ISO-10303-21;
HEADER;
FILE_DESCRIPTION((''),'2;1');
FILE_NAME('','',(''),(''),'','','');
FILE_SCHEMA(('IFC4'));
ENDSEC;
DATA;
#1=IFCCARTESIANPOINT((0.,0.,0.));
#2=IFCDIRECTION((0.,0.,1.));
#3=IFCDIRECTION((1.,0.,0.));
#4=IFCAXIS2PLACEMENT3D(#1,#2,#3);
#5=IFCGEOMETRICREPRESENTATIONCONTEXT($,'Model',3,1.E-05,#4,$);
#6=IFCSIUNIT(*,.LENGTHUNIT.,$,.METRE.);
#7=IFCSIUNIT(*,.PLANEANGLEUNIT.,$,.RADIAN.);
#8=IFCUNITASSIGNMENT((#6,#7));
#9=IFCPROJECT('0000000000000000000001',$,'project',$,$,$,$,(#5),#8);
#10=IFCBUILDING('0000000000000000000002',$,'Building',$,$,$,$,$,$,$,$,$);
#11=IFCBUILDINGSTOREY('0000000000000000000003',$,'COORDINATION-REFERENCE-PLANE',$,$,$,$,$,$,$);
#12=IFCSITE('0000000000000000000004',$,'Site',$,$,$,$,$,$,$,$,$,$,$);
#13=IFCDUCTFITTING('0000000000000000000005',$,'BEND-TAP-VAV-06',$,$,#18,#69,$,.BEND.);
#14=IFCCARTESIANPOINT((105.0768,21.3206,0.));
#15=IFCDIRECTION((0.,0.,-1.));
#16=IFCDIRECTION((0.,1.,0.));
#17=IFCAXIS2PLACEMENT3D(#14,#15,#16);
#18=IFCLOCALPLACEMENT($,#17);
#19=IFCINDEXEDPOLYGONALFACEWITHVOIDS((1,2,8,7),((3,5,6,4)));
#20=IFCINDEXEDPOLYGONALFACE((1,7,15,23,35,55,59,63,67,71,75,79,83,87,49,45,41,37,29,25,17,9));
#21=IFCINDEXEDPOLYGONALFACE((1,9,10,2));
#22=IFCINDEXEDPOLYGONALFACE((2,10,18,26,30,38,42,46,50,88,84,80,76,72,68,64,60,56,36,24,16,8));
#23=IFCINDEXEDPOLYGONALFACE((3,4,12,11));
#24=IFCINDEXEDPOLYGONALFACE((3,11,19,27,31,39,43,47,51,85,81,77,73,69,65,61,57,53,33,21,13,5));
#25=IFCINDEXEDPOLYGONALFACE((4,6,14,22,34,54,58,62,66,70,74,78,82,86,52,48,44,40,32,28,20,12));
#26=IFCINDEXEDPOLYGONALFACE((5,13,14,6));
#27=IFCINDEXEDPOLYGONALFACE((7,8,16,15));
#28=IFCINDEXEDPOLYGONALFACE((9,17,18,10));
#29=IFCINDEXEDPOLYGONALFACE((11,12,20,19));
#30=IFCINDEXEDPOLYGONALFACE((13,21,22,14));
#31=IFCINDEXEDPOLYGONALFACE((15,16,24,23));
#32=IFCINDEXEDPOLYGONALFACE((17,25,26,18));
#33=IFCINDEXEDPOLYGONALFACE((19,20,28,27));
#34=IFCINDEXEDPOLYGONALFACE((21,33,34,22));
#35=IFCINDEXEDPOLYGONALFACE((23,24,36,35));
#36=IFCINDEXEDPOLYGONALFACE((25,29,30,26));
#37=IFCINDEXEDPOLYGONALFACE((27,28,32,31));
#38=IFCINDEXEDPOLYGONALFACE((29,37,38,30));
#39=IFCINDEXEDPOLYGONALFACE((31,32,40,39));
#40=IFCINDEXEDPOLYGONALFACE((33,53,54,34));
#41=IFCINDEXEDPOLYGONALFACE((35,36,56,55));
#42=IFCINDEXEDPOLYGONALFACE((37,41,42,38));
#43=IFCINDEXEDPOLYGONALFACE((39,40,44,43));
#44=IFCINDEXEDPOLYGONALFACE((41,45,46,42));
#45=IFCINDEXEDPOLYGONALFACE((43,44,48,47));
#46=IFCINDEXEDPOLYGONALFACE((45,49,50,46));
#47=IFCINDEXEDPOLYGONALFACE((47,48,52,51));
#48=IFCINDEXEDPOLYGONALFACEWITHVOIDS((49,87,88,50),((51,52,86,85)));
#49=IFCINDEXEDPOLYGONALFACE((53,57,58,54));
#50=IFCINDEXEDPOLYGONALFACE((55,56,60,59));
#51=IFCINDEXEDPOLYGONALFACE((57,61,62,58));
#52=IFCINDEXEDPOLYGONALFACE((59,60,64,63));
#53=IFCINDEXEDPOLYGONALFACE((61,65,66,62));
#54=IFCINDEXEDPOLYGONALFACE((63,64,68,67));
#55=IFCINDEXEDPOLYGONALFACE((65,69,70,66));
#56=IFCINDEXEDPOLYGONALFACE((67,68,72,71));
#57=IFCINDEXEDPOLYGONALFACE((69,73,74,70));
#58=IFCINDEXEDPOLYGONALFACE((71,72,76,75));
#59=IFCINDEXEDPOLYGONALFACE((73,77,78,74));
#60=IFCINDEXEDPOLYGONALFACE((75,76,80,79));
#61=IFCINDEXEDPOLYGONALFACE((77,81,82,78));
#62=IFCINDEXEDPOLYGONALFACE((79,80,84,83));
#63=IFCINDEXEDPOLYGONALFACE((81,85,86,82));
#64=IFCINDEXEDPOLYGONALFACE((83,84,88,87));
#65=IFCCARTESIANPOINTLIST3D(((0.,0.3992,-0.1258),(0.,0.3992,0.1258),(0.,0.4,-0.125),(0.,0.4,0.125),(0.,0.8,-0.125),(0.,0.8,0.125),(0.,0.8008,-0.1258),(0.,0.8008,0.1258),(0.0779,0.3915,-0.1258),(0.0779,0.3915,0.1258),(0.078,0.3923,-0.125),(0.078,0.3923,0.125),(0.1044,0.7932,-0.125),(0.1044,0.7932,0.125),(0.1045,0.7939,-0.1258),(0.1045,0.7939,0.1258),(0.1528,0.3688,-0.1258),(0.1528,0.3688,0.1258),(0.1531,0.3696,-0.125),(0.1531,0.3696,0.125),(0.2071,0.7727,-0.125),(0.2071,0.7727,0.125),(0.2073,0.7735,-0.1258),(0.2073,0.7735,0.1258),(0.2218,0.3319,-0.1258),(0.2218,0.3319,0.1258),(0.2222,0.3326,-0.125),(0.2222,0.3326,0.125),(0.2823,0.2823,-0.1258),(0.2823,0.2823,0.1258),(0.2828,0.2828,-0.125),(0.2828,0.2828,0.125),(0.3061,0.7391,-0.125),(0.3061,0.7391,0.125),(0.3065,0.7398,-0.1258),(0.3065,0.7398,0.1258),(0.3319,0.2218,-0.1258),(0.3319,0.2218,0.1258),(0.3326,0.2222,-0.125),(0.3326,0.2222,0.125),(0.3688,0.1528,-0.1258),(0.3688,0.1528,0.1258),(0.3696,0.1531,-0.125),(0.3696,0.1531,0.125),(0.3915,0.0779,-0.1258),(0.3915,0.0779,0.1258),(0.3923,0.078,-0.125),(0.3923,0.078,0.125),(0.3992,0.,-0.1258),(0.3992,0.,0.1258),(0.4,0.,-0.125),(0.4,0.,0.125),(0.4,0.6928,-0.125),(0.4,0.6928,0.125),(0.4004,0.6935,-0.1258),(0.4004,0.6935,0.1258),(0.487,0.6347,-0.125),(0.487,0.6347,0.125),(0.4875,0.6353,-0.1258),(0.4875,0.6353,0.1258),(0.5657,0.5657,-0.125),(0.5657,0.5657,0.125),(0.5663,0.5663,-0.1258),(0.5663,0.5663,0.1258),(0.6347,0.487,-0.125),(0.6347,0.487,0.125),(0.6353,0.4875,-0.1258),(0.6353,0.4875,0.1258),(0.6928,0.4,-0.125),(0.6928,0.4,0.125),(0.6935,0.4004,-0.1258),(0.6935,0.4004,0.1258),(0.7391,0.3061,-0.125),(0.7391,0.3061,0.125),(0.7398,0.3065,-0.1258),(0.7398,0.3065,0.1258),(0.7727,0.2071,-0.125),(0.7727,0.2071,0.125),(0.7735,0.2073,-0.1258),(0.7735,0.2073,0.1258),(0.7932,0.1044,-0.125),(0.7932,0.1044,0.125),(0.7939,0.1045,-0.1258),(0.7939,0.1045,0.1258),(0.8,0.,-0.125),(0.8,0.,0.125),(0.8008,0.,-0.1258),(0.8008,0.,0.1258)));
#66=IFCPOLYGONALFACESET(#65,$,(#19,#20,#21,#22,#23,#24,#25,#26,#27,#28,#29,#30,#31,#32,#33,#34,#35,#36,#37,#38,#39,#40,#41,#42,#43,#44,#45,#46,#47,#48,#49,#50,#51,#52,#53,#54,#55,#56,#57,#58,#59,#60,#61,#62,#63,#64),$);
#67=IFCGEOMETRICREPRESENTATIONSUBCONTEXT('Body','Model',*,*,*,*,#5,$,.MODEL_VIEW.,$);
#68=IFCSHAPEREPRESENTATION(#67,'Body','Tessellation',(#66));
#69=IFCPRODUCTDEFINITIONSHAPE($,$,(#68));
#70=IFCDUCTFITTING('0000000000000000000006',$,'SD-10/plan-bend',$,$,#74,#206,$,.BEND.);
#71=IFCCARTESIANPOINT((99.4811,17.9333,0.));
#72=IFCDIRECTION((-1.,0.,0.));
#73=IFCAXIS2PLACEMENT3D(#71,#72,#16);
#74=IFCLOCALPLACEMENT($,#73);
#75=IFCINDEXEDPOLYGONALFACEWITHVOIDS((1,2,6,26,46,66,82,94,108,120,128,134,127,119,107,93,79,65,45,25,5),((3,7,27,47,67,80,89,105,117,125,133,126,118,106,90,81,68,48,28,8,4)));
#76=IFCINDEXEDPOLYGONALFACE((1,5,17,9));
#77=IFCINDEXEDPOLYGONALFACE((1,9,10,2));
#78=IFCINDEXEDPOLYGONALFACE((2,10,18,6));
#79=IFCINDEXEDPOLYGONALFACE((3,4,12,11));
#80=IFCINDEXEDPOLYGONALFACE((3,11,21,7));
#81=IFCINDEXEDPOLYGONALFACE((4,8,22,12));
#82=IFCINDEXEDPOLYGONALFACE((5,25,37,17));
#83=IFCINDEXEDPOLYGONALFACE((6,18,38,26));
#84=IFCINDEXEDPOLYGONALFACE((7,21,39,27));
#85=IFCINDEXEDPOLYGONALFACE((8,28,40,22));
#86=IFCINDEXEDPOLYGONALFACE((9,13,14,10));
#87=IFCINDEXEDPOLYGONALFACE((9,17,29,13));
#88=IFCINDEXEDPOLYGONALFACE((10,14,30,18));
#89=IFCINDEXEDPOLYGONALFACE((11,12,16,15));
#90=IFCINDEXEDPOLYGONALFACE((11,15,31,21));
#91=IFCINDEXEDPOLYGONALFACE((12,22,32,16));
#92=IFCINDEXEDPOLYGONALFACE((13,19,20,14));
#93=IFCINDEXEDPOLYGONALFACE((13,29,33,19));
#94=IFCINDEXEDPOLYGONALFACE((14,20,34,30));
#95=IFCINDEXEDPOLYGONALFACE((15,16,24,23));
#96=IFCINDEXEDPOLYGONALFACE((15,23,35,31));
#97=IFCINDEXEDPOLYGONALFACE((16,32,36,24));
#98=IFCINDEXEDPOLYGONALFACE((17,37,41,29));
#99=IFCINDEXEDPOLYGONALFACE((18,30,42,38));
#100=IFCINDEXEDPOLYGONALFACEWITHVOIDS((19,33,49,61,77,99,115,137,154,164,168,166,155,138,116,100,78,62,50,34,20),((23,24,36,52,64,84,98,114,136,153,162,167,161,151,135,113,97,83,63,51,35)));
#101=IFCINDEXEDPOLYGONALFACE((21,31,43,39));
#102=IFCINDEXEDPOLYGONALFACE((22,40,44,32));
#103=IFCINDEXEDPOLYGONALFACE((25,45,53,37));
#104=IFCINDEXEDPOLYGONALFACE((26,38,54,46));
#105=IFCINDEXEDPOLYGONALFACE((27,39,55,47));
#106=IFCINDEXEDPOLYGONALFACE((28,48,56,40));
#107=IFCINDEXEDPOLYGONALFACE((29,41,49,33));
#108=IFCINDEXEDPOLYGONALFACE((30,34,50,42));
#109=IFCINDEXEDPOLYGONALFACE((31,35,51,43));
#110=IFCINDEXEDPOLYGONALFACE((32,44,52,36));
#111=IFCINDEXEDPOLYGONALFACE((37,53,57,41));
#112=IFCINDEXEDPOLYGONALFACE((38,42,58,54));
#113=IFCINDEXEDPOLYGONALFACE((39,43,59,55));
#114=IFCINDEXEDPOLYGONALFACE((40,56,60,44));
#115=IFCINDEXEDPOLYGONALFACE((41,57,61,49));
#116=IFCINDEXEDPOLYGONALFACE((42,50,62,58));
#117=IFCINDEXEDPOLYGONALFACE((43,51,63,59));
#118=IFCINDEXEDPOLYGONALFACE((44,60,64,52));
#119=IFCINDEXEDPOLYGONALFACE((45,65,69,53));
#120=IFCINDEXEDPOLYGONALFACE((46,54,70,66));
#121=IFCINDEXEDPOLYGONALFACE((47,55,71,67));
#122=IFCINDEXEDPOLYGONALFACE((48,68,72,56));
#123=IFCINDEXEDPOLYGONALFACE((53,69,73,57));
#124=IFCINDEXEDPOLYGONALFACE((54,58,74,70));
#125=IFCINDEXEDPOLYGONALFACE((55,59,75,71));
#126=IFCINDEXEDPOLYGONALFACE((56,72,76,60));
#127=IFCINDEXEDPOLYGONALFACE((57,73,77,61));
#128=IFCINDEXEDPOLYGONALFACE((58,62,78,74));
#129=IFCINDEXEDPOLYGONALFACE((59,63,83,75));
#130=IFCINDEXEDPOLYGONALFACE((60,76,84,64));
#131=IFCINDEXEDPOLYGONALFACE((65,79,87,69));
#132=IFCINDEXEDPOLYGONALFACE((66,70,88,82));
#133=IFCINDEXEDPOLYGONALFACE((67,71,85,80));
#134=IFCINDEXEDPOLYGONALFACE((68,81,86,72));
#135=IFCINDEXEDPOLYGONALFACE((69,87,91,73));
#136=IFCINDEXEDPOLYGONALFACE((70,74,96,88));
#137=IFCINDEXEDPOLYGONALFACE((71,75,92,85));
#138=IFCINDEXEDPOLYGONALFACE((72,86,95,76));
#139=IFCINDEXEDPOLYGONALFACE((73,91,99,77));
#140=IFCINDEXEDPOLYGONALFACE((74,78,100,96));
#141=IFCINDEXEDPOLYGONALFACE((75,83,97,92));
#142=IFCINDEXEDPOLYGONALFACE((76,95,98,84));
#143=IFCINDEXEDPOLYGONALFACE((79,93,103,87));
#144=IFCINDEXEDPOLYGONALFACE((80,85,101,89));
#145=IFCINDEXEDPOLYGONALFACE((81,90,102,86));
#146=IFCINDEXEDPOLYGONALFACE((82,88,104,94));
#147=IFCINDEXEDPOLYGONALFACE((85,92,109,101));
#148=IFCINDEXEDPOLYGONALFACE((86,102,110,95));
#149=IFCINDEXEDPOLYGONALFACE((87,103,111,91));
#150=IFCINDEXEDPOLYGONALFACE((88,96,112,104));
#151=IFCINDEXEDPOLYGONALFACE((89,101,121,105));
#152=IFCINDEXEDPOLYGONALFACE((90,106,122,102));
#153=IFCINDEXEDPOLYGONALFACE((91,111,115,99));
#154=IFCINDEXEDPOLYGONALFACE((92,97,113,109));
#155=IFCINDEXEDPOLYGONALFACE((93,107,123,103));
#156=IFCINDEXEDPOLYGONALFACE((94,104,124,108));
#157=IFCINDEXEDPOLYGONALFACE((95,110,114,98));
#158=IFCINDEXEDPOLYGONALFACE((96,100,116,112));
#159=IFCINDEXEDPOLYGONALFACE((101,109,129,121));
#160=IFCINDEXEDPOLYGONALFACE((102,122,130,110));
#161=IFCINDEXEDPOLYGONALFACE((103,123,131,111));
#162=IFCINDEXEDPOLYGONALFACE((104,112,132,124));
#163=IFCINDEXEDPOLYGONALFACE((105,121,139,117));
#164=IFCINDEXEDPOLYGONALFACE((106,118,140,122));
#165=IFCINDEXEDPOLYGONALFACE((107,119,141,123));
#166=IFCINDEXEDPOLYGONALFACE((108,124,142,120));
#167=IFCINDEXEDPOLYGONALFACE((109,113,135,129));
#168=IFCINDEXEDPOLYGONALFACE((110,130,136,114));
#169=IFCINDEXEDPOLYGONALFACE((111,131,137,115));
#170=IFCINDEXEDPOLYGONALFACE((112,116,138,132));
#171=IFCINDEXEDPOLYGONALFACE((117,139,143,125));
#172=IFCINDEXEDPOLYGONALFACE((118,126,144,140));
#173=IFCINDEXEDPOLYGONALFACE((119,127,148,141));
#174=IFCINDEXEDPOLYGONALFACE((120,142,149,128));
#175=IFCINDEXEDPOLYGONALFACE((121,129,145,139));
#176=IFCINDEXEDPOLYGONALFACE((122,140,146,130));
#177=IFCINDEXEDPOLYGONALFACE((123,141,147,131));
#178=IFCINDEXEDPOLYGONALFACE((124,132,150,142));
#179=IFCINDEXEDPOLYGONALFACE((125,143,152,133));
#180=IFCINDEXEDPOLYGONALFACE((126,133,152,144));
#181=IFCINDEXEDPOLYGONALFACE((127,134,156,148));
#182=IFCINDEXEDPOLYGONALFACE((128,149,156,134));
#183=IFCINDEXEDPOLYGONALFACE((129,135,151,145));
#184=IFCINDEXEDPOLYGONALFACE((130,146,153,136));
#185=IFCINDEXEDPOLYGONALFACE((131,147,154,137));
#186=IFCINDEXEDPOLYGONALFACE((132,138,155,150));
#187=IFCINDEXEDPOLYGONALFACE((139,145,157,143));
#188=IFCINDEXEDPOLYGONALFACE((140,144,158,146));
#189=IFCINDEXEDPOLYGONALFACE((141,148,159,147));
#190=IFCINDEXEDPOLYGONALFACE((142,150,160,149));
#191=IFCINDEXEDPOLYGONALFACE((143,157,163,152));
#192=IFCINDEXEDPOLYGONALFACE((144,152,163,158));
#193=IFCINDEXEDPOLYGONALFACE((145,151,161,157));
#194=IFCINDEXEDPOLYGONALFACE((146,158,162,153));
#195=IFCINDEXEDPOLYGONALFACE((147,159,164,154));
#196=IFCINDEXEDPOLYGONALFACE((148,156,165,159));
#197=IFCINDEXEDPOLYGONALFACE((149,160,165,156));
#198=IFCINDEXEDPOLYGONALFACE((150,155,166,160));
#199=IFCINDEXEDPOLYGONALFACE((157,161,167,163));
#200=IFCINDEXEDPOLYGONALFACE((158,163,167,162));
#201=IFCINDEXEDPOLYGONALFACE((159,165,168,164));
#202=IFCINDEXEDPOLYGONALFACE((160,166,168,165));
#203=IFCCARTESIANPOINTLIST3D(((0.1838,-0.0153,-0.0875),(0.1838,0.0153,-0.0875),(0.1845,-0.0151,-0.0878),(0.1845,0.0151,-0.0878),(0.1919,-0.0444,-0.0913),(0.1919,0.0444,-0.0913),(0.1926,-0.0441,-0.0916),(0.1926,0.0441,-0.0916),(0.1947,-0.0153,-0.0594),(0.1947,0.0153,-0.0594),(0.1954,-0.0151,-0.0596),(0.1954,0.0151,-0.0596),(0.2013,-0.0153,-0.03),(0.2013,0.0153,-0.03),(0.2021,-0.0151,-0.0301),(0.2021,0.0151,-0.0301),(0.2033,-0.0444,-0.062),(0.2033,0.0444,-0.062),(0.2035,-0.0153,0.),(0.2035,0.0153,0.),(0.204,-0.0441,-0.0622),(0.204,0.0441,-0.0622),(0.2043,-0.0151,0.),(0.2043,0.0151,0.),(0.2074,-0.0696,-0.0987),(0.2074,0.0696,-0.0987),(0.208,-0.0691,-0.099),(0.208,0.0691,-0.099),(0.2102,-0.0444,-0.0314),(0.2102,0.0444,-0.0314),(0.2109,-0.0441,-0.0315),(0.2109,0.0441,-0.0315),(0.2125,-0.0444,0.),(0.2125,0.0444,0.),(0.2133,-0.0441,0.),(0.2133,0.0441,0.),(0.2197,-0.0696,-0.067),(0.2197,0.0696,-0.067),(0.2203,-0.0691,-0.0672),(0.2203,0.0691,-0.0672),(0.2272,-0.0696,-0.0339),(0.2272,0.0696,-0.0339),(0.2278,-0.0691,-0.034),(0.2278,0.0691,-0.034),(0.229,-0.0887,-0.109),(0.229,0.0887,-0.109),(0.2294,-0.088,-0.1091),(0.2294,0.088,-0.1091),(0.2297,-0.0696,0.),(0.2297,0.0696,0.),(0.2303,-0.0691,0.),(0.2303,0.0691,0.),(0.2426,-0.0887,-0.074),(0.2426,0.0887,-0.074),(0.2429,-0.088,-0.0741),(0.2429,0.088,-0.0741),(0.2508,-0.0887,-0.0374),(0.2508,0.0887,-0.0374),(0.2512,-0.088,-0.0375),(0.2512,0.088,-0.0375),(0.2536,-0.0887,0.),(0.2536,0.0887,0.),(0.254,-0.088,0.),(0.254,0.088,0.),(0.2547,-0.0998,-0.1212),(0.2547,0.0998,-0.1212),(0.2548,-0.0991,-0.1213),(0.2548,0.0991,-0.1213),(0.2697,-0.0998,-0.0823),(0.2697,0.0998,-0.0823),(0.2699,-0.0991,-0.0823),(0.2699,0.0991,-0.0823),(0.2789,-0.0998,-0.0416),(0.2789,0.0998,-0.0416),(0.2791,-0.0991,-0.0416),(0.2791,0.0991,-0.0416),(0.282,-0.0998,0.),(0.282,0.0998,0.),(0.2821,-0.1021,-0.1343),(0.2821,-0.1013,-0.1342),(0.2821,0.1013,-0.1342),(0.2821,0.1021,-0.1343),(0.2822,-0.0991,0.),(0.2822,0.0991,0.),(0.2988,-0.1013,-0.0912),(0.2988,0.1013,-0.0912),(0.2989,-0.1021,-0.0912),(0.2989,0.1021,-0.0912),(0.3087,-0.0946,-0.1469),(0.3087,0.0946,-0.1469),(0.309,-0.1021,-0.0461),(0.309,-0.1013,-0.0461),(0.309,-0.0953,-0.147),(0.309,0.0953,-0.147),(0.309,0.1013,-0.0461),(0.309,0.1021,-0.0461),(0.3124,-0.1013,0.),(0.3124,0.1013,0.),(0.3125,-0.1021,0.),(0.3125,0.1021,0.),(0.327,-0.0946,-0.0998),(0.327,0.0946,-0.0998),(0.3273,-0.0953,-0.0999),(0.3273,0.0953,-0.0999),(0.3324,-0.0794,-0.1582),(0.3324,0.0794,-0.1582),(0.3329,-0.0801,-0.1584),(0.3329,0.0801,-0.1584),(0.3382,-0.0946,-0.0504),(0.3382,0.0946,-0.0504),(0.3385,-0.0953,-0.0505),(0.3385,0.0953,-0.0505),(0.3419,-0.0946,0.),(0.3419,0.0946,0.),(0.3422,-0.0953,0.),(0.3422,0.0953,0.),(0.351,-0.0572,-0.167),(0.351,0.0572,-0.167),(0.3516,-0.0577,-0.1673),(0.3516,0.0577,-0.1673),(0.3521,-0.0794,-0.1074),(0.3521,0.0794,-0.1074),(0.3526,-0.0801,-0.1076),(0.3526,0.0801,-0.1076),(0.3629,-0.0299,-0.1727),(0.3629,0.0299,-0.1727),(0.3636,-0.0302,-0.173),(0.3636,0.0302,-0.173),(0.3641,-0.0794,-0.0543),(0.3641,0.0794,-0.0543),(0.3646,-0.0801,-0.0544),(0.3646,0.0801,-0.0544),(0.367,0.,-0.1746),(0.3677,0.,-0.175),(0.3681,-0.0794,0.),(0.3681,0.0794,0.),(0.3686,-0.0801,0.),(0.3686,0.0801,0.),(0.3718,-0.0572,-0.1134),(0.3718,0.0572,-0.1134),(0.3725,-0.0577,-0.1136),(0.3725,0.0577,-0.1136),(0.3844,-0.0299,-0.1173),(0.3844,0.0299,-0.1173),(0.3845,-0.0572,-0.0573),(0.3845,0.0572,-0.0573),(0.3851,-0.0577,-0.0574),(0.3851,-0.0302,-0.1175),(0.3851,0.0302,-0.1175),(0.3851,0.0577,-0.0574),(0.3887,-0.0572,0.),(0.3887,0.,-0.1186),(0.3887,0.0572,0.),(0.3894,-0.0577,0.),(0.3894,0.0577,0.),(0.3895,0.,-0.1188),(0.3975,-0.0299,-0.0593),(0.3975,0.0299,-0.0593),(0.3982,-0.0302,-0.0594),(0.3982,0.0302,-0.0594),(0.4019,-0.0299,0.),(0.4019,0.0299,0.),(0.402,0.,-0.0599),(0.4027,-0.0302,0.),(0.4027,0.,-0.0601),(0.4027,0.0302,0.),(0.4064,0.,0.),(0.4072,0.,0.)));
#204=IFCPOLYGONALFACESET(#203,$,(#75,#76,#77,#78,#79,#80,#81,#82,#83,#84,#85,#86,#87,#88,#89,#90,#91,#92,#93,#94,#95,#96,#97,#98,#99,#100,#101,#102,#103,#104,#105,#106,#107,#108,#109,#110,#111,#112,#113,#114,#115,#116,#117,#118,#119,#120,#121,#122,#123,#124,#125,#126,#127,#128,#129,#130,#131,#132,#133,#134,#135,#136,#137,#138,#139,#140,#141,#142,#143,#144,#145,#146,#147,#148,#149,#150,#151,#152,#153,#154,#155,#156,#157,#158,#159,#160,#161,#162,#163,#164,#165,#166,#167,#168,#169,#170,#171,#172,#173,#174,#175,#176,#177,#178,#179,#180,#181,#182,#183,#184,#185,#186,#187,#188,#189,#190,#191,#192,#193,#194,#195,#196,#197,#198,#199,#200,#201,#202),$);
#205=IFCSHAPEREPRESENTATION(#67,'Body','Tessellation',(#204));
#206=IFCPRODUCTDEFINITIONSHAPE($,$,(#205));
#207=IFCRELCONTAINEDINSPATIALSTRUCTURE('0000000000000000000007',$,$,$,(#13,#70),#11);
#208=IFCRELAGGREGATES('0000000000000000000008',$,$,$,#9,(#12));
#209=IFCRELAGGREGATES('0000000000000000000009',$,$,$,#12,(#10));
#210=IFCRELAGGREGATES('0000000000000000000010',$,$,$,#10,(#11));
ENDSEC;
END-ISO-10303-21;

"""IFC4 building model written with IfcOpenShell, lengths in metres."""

from ifc_helpers import new_model, entity, si_unit, frame, origin_with_axes, place, context, subcontext, project, spatial, element, save


model = new_model("IFC4")

# Units and contexts
model_context = context("Model", 3, precision=1e-05, world=origin_with_axes())
body_context_1 = subcontext(model_context, "Body", "Model", "MODEL_VIEW")
ifc_project = project(units=[si_unit("LENGTHUNIT", "METRE"), si_unit("PLANEANGLEUNIT", "RADIAN")], contexts=[model_context])

# Site, building, storey
site = spatial("IfcSite", under=ifc_project, Name="Site")
building = spatial("IfcBuilding", under=site, Name="Building")
storey = spatial("IfcBuildingStorey", under=building, Name="COORDINATION-REFERENCE-PLANE")

# Duct fitting
duct_fitting_1_placement = place(None, frame((105.0768, 21.3206, 0.0), z_axis=(0.0, 0.0, -1.0), x_axis=(0.0, 1.0, 0.0)))
cartesian_point = entity("IfcCartesianPoint", [0.0, 0.0, 0.0])
element("IfcDuctFitting", 1, at=duct_fitting_1_placement, inside=storey, Name="BEND-TAP-VAV-06", PredefinedType="BEND", context=body_context_1, shape_type="SweptSolid", body=[
    entity("IfcRevolvedAreaSolid", entity("IfcRectangleHollowProfileDef", "AREA", None, entity("IfcAxis2Placement2D", entity("IfcCartesianPoint", [0.6, 0.0])), 0.4016, 0.2516, 0.0008), entity("IfcAxis2Placement3D", cartesian_point, entity("IfcDirection", [0.0, -1.0, 0.0]), entity("IfcDirection", [1.0, 0.0, 0.0])), entity("IfcAxis1Placement", cartesian_point, entity("IfcDirection", [0.0, 1.0, 0.0])), 1.570796),
])

# Duct fitting
duct_fitting_2_placement = place(None, frame((99.4811, 17.9333, 0.0), z_axis=(-1.0, 0.0, 0.0), x_axis=(0.0, 1.0, 0.0)))
element("IfcDuctFitting", 2, at=duct_fitting_2_placement, inside=storey, Name="SD-10/plan-bend", PredefinedType="BEND", context=body_context_1, shape_type="SweptSolid", body=[
    entity("IfcRevolvedAreaSolid", entity("IfcCircleHollowProfileDef", "AREA", None, entity("IfcAxis2Placement2D", entity("IfcCartesianPoint", [0.3048, 0.0])), 0.1024, 0.0008), entity("IfcAxis2Placement3D", entity("IfcCartesianPoint", [0.0, 0.0, 0.0]), entity("IfcDirection", [0.0, 0.0, 1.0]), entity("IfcDirection", [1.0, 0.0, 0.0])), entity("IfcAxis1Placement", entity("IfcCartesianPoint", [0.0, 0.0, 0.0]), entity("IfcDirection", [0.0, 1.0, 0.0])), 0.444153),
])

save(model, "model.ifc")
